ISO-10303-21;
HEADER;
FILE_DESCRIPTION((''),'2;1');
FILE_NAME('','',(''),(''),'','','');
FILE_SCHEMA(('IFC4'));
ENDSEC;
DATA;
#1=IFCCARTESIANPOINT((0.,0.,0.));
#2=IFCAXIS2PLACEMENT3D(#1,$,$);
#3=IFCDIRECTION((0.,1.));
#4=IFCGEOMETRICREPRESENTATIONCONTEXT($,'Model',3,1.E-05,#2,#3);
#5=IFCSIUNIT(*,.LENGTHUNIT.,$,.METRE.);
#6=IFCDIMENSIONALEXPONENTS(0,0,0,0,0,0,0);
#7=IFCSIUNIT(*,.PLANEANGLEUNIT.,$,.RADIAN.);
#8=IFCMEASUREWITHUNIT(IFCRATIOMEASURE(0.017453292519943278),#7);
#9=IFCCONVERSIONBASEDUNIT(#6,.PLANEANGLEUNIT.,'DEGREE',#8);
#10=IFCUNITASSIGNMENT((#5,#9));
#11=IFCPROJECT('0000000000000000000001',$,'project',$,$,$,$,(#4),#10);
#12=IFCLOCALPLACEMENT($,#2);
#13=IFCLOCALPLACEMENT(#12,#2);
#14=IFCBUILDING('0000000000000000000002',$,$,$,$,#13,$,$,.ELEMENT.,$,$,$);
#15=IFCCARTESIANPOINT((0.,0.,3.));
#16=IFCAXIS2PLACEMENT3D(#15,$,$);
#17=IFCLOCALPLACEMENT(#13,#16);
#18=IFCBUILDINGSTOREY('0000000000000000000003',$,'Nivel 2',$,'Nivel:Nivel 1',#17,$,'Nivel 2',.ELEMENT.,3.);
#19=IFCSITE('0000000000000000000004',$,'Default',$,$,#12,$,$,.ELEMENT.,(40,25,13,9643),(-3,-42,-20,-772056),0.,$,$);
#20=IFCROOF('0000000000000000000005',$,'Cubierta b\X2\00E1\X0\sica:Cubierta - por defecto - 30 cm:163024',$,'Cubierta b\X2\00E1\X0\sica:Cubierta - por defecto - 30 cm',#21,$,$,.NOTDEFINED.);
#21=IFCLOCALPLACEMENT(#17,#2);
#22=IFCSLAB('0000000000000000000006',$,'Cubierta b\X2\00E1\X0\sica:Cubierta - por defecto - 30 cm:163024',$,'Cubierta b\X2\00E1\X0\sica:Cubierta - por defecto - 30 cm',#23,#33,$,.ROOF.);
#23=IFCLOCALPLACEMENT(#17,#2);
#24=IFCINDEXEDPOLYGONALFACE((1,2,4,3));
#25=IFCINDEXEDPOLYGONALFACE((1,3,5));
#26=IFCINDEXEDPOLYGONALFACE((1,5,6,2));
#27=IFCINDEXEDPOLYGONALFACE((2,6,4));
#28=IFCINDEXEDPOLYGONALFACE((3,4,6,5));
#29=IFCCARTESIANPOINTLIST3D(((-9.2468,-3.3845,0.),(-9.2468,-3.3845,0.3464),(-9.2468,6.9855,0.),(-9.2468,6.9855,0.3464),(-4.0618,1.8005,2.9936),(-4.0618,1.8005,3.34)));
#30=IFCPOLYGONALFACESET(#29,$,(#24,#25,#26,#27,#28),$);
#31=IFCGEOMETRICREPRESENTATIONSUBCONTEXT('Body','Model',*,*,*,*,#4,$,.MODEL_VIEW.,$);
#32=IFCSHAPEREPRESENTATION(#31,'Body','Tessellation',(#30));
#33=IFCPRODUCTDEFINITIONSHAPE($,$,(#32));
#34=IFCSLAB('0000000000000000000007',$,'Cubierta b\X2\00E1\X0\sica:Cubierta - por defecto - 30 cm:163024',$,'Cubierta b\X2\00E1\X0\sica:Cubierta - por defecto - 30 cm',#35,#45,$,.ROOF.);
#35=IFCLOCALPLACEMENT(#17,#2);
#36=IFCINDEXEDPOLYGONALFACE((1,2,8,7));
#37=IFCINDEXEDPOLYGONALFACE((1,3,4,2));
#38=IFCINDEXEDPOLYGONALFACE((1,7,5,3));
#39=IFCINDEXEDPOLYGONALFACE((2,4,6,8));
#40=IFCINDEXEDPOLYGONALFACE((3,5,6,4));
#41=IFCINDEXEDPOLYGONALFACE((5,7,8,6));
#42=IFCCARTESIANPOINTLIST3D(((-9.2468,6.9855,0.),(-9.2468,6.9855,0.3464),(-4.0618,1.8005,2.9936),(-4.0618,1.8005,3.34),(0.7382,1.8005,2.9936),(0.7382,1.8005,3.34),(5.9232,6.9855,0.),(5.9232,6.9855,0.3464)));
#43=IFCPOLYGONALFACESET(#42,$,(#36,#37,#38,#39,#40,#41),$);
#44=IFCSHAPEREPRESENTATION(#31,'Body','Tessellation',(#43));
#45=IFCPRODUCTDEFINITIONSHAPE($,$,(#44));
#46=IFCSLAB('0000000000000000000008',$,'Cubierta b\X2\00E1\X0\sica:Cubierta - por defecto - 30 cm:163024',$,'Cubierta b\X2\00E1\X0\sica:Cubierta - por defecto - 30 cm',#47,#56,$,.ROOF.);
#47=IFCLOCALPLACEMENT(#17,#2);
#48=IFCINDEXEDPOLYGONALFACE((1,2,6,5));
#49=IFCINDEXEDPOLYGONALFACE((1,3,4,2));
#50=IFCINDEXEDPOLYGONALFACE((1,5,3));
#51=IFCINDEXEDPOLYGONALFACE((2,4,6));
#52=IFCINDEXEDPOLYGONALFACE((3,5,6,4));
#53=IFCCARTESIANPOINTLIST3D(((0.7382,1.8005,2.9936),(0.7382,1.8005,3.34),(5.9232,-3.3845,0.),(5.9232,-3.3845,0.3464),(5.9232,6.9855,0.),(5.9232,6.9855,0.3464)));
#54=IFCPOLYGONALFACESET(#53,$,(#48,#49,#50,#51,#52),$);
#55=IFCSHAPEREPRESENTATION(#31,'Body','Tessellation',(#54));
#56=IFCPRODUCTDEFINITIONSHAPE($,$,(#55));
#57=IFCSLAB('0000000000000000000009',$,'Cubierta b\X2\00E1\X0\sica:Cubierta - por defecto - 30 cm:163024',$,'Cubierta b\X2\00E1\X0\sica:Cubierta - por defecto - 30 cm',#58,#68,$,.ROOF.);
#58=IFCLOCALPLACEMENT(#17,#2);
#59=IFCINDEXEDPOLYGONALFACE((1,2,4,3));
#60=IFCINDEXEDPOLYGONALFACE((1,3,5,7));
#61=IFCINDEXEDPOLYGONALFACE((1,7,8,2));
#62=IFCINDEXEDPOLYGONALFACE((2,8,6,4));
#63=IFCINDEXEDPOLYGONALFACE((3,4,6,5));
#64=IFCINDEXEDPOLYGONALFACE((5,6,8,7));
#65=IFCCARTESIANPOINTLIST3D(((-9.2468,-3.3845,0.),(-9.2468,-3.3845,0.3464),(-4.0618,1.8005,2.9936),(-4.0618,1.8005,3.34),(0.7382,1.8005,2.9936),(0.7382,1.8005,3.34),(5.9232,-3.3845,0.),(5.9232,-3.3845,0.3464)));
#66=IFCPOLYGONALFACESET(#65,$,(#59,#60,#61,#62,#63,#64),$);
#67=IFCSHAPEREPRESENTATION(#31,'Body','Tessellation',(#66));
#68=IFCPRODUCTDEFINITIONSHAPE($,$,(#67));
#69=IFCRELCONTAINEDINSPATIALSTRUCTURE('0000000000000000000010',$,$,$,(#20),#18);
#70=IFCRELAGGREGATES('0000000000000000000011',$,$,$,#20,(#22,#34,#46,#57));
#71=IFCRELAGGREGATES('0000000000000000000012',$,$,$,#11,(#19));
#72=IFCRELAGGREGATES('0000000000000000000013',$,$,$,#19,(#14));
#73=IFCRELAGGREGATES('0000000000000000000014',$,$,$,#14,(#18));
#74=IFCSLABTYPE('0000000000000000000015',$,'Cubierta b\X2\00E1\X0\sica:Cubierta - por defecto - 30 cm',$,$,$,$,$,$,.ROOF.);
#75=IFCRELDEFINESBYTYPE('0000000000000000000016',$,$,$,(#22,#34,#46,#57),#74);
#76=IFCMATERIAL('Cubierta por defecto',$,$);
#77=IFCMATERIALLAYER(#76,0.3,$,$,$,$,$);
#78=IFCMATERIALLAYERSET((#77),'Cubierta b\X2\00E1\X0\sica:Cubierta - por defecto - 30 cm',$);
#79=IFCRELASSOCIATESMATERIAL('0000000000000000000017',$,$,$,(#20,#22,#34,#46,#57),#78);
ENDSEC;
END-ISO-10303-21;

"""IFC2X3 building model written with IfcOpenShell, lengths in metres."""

from ifc_helpers import new_model, entity, si_unit, converted_unit, direction, frame, origin, place, context, subcontext, project, spatial, polyline, outline, extrude, material, layer, layer_set, type_object, element, aggregate, save


model = new_model("IFC2X3")

# Units and contexts
model_context = context("Model", 3, precision=1e-05, world=origin(), true_north=direction((0.0, 1.0)))
body_context = subcontext(model_context, "Body", "Model", "MODEL_VIEW")
ifc_project = project(units=[si_unit("LENGTHUNIT", "METRE"), converted_unit("PLANEANGLEUNIT", "DEGREE", entity("IfcRatioMeasure", 0.017453292519943278), si_unit("PLANEANGLEUNIT", "RADIAN"), dimensions=[0, 0, 0, 0, 0, 0, 0])], contexts=[model_context])

# Site, building, storey
site_placement = place(None, origin())
site = spatial("IfcSite", under=ifc_project, at=site_placement, Name="Default", CompositionType="ELEMENT", RefLatitude=(40, 25, 13, 9643), RefLongitude=(-3, -42, -20, -772056), RefElevation=0.0)
building_placement = place(site_placement, origin())
building = spatial("IfcBuilding", under=site, at=building_placement, CompositionType="ELEMENT")
storey_placement = place(building_placement, frame((0.0, 0.0, 3.0)))
storey = spatial("IfcBuildingStorey", under=building, at=storey_placement, Name="Nivel 2", ObjectType="Nivel:Nivel 1", LongName="Nivel 2", CompositionType="ELEMENT", Elevation=3.0)

# Roof, slabs
ifc_material = material(Name="Cubierta por defecto")
ifc_layer = layer(ifc_material, 0.3)
ifc_layer_set = layer_set([ifc_layer], Name="Cubierta básica:Cubierta - por defecto - 30 cm")
roof_placement = place(storey_placement, frame((-9.2468, -3.3845, 0.0)))
roof = element("IfcRoof", 1, at=roof_placement, inside=storey, material=ifc_layer_set, Name="Cubierta básica:Cubierta - por defecto - 30 cm:163024", ObjectType="Cubierta básica:Cubierta - por defecto - 30 cm", ShapeType="NOTDEFINED")
slab_type = type_object("IfcSlabType", Name="Cubierta básica:Cubierta - por defecto - 30 cm", PredefinedType="ROOF")
slab_1_placement = place(roof_placement, origin())
slab_1 = element("IfcSlab", 2, at=slab_1_placement, type_object=slab_type, material=ifc_layer_set, Name="Cubierta básica:Cubierta - por defecto - 30 cm:163024", ObjectType="Cubierta básica:Cubierta - por defecto - 30 cm", PredefinedType="ROOF", context=body_context, shape_type="SweptSolid", body=[
    extrude(outline(polyline([(2.9936, 0.0), (-2.9936, 5.185), (-2.9936, -5.185), (2.9936, 0.0)])), frame((2.5925, 5.185, 1.4968), z_axis=(-0.5, 0.0, 0.866025), x_axis=(0.866025, 0.0, 0.5)), (0.5, 0.0, 0.866025), 0.3464),
])
slab_2_placement = place(roof_placement, origin())
slab_2 = element("IfcSlab", 3, at=slab_2_placement, type_object=slab_type, material=ifc_layer_set, Name="Cubierta básica:Cubierta - por defecto - 30 cm:163024", ObjectType="Cubierta básica:Cubierta - por defecto - 30 cm", PredefinedType="ROOF", context=body_context, shape_type="SweptSolid", body=[
    extrude(outline(polyline([(7.585, 2.9936), (-7.585, 2.9936), (-2.4, -2.9936), (2.4, -2.9936), (7.585, 2.9936)])), frame((7.585, 7.7775, 1.4968), z_axis=(0.0, 0.5, 0.866025), x_axis=(1.0, 0.0, 0.0)), (0.0, -0.5, 0.866025), 0.3464),
])
slab_3_placement = place(roof_placement, origin())
slab_3 = element("IfcSlab", 4, at=slab_3_placement, type_object=slab_type, material=ifc_layer_set, Name="Cubierta básica:Cubierta - por defecto - 30 cm:163024", ObjectType="Cubierta básica:Cubierta - por defecto - 30 cm", PredefinedType="ROOF", context=body_context, shape_type="SweptSolid", body=[
    extrude(outline(polyline([(2.9936, -5.185), (2.9936, 5.185), (-2.9936, 0.0), (2.9936, -5.185)])), frame((12.5775, 5.185, 1.4968), z_axis=(0.5, 0.0, 0.866025), x_axis=(0.866025, 0.0, -0.5)), (-0.5, 0.0, 0.866025), 0.3464),
])
slab_4_placement = place(roof_placement, origin())
slab_4 = element("IfcSlab", 5, at=slab_4_placement, type_object=slab_type, material=ifc_layer_set, Name="Cubierta básica:Cubierta - por defecto - 30 cm:163024", ObjectType="Cubierta básica:Cubierta - por defecto - 30 cm", PredefinedType="ROOF", context=body_context, shape_type="SweptSolid", body=[
    extrude(outline(polyline([(-7.585, -2.9936), (7.585, -2.9936), (2.4, 2.9936), (-2.4, 2.9936), (-7.585, -2.9936)])), frame((7.585, 2.5925, 1.4968), z_axis=(0.0, -0.5, 0.866025), x_axis=(1.0, 0.0, 0.0)), (0.0, 0.5, 0.866025), 0.3464),
])
aggregate(roof, [slab_1, slab_2, slab_3, slab_4])

save(model, "model.ifc")
